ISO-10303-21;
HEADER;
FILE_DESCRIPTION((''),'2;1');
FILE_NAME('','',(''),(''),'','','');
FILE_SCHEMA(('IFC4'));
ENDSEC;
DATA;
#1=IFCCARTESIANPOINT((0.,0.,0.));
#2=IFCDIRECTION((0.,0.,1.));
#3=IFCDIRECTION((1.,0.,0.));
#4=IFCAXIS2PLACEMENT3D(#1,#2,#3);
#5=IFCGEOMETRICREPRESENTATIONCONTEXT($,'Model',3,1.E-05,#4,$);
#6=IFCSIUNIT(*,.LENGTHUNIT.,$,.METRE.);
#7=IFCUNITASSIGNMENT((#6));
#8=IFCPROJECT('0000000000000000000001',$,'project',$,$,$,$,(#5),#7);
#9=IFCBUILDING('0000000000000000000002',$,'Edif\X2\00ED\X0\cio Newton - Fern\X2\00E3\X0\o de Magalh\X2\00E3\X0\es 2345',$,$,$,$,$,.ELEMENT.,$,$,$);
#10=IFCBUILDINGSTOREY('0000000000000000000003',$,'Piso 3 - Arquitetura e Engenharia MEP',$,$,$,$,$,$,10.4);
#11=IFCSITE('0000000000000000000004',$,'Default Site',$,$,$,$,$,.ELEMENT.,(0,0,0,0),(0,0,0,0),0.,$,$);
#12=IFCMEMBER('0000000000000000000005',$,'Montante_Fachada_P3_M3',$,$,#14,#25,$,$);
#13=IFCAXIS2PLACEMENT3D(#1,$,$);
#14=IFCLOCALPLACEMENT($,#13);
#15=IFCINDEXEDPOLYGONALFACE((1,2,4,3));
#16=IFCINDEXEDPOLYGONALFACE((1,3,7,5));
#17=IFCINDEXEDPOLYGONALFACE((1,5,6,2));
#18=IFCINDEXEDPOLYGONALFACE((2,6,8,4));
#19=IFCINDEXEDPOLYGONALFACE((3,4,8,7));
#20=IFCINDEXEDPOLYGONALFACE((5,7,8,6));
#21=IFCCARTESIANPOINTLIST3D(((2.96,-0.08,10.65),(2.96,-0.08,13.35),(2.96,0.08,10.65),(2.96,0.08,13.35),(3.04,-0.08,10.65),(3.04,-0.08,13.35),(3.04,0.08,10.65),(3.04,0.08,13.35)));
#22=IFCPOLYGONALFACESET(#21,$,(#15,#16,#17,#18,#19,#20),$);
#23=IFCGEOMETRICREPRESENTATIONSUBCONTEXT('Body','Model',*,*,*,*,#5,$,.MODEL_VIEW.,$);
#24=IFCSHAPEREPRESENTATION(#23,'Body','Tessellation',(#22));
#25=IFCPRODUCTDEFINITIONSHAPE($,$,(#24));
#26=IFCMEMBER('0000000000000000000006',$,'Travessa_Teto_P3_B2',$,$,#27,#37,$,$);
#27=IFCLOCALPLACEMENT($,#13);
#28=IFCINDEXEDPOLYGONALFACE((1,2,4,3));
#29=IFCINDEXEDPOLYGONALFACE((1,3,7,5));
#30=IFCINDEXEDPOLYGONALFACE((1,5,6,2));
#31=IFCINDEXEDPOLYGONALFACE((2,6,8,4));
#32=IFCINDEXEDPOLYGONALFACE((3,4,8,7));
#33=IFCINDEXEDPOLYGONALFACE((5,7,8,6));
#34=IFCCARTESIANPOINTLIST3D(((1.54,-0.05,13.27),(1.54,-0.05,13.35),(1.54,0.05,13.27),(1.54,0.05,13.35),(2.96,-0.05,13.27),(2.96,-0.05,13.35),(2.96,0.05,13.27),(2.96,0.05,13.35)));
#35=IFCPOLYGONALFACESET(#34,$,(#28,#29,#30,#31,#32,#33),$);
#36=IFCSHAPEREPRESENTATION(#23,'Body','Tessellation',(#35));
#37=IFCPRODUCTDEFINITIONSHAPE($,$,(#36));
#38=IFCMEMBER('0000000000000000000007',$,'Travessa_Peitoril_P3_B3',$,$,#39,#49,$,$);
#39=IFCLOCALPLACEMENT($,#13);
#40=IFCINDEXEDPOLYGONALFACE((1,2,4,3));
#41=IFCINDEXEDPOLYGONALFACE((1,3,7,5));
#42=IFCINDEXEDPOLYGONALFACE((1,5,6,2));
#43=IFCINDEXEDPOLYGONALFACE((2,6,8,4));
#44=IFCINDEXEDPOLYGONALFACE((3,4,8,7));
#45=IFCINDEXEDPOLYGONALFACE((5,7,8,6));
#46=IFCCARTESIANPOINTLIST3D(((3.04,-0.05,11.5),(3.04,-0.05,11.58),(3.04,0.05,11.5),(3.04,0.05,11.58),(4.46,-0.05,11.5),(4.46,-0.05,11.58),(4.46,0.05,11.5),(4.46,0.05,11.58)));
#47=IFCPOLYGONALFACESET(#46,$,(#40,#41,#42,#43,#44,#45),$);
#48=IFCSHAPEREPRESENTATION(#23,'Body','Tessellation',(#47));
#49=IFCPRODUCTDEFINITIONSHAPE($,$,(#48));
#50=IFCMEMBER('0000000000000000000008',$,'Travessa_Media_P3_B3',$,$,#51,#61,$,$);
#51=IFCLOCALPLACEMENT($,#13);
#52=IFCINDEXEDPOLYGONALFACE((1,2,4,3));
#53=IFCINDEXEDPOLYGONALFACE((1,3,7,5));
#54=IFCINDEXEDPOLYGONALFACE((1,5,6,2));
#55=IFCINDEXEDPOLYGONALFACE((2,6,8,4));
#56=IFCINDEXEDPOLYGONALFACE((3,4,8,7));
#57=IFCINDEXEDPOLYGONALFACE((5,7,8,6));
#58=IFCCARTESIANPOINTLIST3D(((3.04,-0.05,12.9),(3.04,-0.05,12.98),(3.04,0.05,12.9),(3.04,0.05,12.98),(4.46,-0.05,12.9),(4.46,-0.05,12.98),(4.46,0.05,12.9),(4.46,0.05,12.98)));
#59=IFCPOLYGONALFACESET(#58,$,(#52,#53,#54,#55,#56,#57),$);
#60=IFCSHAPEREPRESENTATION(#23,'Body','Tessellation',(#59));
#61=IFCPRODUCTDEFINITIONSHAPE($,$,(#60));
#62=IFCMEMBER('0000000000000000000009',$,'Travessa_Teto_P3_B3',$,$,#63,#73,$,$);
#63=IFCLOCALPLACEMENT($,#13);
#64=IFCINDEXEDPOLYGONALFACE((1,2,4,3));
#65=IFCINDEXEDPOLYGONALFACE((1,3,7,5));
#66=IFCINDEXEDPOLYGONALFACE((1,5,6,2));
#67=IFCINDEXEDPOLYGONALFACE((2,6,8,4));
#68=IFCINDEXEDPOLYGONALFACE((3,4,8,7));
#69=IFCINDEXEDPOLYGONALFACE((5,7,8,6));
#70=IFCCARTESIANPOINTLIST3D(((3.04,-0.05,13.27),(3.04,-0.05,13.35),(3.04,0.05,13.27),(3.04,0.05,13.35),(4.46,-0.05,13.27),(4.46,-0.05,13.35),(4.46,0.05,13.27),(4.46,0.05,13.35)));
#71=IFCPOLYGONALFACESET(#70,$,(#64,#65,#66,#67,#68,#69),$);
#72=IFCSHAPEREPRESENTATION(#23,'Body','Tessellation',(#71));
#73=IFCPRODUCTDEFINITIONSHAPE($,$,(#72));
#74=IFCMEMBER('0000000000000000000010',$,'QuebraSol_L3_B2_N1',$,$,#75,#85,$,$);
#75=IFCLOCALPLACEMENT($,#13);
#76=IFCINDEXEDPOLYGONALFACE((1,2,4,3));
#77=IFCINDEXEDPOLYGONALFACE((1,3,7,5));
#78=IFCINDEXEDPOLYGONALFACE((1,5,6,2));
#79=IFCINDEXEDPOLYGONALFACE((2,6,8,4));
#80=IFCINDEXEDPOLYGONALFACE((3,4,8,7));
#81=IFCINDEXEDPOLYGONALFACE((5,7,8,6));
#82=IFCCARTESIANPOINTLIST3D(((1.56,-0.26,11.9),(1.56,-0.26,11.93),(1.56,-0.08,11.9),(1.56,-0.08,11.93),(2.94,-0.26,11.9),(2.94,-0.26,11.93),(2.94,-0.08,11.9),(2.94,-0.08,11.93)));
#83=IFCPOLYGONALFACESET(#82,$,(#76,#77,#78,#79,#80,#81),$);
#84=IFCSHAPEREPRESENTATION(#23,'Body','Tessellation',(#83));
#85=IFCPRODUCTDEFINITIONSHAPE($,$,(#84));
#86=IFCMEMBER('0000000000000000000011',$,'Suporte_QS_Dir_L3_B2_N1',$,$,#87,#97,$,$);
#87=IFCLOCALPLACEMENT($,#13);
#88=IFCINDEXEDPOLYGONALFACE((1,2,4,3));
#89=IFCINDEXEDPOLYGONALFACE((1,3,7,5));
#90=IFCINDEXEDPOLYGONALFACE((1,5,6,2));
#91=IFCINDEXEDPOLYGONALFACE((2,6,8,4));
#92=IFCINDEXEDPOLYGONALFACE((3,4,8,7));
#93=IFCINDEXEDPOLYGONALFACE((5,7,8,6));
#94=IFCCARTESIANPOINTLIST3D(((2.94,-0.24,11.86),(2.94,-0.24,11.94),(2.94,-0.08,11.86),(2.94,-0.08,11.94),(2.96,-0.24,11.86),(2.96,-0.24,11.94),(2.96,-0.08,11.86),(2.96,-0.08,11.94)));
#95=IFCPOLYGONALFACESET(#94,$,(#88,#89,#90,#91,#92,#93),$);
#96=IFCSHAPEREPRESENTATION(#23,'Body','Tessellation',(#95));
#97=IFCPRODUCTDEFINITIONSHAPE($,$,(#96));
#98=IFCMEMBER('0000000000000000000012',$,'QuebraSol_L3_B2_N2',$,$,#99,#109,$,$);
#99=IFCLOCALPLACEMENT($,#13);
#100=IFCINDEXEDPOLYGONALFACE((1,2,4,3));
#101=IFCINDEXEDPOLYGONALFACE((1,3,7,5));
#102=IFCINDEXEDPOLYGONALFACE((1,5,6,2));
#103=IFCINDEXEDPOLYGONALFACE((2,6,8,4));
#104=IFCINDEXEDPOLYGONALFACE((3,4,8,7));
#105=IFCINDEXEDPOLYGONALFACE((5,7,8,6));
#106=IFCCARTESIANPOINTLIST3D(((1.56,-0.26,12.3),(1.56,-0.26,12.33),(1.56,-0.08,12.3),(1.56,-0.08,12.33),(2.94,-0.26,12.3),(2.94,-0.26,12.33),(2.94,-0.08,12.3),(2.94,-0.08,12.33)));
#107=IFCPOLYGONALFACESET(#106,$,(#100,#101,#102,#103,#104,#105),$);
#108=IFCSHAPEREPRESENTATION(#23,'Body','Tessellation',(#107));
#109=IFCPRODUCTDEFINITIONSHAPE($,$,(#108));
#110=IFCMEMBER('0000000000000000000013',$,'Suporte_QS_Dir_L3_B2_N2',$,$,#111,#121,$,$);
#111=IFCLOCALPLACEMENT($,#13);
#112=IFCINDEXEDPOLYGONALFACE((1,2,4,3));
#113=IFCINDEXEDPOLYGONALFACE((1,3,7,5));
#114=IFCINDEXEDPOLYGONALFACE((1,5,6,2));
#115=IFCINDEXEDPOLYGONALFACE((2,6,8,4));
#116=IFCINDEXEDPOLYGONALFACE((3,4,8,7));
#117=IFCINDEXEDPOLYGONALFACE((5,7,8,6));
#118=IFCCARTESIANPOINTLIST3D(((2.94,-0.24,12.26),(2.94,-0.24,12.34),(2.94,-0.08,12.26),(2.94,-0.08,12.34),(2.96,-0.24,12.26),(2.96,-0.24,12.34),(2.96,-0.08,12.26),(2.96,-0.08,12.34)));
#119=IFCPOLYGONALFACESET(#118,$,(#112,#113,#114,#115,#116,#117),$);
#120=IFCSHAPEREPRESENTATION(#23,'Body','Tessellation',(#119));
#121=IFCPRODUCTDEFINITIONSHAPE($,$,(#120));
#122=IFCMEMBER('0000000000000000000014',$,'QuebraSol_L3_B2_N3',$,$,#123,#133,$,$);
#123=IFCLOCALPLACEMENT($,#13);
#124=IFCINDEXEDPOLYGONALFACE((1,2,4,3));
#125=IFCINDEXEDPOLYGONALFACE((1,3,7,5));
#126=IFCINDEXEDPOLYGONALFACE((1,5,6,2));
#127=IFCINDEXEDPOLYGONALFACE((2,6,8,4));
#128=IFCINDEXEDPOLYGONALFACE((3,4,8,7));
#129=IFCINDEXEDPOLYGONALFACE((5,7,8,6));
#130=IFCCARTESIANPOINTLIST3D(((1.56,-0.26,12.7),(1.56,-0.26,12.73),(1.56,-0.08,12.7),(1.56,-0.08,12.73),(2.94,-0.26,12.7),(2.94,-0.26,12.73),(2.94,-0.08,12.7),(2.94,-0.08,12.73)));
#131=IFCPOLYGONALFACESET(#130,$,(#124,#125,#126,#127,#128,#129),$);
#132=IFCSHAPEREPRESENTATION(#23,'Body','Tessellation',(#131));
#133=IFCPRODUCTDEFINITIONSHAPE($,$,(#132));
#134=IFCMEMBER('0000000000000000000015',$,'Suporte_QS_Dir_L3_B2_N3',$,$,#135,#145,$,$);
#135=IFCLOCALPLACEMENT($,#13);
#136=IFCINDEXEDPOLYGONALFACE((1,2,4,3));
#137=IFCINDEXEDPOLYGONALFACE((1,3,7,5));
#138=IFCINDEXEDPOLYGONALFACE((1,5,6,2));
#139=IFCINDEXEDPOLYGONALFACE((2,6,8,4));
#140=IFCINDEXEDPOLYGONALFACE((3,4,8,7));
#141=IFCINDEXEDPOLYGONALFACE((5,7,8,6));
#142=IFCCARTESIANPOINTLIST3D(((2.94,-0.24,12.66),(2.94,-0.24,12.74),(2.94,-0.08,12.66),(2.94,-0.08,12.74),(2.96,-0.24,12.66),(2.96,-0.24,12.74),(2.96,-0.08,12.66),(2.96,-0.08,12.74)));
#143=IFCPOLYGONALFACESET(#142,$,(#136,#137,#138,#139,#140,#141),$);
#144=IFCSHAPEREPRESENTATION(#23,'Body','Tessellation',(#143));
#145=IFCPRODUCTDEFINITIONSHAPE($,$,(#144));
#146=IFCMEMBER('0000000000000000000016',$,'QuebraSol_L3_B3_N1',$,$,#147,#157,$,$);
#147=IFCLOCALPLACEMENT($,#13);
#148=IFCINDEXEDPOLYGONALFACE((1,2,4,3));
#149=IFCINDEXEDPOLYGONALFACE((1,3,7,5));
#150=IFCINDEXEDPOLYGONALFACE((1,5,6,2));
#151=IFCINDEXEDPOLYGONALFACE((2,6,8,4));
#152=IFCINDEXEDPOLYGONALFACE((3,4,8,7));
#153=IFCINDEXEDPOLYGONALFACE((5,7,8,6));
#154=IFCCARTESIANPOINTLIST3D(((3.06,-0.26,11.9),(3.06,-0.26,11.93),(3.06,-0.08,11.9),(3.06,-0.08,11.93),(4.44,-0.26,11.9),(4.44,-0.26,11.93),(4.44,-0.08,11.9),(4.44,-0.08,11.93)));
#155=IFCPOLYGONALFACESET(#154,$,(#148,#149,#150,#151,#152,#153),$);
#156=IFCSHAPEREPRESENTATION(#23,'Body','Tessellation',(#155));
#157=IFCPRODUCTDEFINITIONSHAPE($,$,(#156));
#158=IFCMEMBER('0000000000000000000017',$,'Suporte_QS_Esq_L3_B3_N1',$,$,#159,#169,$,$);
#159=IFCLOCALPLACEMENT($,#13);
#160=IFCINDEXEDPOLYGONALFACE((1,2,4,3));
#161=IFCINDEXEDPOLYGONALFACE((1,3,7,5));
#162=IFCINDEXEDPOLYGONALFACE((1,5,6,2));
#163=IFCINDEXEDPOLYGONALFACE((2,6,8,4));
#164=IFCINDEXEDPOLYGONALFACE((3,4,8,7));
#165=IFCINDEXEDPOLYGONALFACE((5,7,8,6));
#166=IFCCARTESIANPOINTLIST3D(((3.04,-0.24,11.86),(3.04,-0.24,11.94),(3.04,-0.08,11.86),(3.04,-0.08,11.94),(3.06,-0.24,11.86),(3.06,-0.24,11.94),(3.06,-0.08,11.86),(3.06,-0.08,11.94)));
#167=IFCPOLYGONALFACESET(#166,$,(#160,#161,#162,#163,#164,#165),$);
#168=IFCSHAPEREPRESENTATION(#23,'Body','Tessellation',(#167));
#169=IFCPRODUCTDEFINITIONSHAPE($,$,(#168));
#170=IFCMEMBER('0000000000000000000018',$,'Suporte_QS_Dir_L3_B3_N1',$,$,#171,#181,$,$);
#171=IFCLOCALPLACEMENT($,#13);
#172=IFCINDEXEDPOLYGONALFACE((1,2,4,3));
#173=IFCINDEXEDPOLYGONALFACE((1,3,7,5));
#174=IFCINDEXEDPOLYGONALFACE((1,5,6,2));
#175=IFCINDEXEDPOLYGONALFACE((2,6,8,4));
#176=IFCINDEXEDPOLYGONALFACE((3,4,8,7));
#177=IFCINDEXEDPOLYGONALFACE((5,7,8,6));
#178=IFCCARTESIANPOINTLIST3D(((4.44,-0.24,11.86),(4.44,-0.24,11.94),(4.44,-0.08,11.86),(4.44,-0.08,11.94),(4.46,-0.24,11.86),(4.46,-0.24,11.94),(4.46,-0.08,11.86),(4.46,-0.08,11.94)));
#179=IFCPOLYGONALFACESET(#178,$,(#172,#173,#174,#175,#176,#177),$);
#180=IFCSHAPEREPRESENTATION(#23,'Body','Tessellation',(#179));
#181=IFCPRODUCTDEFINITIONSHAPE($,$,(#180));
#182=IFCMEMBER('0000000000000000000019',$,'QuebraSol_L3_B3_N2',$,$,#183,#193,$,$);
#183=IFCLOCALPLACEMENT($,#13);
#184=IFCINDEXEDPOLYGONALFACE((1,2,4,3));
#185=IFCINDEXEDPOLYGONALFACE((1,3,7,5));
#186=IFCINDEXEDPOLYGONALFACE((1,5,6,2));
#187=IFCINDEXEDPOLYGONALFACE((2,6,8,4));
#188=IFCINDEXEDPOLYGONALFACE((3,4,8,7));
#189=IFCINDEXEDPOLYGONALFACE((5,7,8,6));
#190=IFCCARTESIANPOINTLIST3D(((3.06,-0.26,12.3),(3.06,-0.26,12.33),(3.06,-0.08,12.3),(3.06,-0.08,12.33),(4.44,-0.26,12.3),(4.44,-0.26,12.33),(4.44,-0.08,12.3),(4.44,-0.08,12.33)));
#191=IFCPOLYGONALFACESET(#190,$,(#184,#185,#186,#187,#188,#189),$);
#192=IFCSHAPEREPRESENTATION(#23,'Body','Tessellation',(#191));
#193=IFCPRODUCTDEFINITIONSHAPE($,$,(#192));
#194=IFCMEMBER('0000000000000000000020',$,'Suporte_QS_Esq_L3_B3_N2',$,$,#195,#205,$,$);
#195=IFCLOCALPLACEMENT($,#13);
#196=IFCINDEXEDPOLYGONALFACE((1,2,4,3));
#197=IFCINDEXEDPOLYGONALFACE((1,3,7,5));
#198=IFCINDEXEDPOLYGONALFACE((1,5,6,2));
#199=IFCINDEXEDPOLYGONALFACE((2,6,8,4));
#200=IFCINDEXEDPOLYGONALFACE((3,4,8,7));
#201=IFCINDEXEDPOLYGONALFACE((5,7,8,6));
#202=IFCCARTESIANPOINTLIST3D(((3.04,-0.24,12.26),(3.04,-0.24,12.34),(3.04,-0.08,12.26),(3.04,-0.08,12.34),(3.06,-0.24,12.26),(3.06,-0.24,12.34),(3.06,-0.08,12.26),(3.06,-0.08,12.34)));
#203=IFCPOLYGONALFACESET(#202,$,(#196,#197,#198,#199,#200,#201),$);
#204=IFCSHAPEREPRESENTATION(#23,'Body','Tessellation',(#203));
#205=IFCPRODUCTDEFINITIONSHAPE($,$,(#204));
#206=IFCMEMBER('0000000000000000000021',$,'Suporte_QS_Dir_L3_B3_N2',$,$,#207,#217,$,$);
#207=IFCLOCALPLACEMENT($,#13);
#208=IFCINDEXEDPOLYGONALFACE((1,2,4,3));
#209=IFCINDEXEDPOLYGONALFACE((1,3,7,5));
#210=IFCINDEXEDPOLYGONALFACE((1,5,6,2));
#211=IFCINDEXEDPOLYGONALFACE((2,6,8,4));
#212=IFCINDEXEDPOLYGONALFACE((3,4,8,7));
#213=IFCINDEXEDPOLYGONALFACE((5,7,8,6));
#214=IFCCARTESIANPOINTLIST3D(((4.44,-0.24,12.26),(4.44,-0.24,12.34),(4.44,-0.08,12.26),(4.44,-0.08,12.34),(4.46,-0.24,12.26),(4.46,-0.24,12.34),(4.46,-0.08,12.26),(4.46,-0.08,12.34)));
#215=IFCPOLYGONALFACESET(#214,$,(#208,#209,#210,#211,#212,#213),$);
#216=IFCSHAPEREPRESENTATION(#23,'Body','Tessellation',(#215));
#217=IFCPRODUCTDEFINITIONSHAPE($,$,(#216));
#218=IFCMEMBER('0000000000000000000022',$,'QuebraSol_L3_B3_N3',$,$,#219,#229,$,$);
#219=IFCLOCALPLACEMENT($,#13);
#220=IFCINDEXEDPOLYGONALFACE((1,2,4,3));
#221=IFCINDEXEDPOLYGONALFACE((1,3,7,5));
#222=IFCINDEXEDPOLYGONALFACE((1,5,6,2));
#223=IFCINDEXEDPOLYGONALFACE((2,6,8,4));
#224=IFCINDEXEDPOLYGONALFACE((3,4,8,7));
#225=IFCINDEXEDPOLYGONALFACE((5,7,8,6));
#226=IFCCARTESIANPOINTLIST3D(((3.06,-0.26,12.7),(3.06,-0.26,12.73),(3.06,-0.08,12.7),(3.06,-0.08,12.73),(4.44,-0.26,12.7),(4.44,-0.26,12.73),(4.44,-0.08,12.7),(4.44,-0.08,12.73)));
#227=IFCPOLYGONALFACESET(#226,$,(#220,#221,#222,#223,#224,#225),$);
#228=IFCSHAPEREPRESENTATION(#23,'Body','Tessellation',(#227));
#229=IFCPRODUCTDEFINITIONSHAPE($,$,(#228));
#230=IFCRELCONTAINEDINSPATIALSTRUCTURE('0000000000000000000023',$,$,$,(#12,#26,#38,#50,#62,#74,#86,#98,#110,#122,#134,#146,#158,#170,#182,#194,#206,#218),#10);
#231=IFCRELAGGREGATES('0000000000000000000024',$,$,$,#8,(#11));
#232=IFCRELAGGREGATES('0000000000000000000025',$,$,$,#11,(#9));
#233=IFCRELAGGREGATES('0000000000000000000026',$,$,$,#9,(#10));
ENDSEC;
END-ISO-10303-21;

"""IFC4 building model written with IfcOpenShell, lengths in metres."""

from ifc_helpers import new_model, si_unit, frame, frame_2d, origin_with_axes, place, context, subcontext, project, spatial, rectangle, extrude, element, save


model = new_model("IFC4")

# Units and contexts
model_context = context("Model", 3, precision=1e-05, world=origin_with_axes())
body_context = subcontext(model_context, "Body", "Model", "MODEL_VIEW")
ifc_project = project(units=[si_unit("LENGTHUNIT", "METRE")], contexts=[model_context])

# Site, building, storey
site = spatial("IfcSite", under=ifc_project, Name="Default Site", CompositionType="ELEMENT", RefLatitude=(0, 0, 0, 0), RefLongitude=(0, 0, 0, 0), RefElevation=0.0)
building = spatial("IfcBuilding", under=site, Name="Edifício Newton - Fernão de Magalhães 2345", CompositionType="ELEMENT")
storey = spatial("IfcBuildingStorey", under=building, Name="Piso 3 - Arquitetura e Engenharia MEP", Elevation=10.4)

# Members
member_1_placement = place(None, frame((2.96, -0.08, 10.65), z_axis=(0.0, 0.0, 1.0), x_axis=(1.0, 0.0, 0.0)))
element("IfcMember", 1, at=member_1_placement, inside=storey, Name="Montante_Fachada_P3_M3", context=body_context, shape_type="SweptSolid", body=[
    extrude(rectangle(XDim=0.08, YDim=0.16, at=frame_2d((0.04, 0.08))), origin_with_axes(), (0.0, 0.0, 1.0), 2.7),
])
for number, where, z_axis, x_axis, name in (
    (2, (1.54, -0.05, 13.27), (0.0, 0.0, 1.0), (1.0, 0.0, 0.0), "Travessa_Teto_P3_B2"),
    (3, (3.04, -0.05, 11.5), (0.0, 0.0, 1.0), (1.0, 0.0, 0.0), "Travessa_Peitoril_P3_B3"),
    (4, (3.04, -0.05, 12.9), (0.0, 0.0, 1.0), (1.0, 0.0, 0.0), "Travessa_Media_P3_B3"),
    (5, (3.04, -0.05, 13.27), (0.0, 0.0, 1.0), (1.0, 0.0, 0.0), "Travessa_Teto_P3_B3"),
):
    element("IfcMember", number, at=place(None, frame(where, z_axis=z_axis, x_axis=x_axis)), inside=storey, Name=name, context=body_context, shape_type="SweptSolid", body=[
        extrude(rectangle(XDim=1.42, YDim=0.1, at=frame_2d((0.71, 0.05))), origin_with_axes(), (0.0, 0.0, 1.0), 0.08),
    ])
member_2_placement = place(None, frame((1.56, -0.26, 11.9), z_axis=(0.0, 0.0, 1.0), x_axis=(1.0, 0.0, 0.0)))
element("IfcMember", 6, at=member_2_placement, inside=storey, Name="QuebraSol_L3_B2_N1", context=body_context, shape_type="SweptSolid", body=[
    extrude(rectangle(XDim=1.38, YDim=0.18, at=frame_2d((0.69, 0.09))), origin_with_axes(), (0.0, 0.0, 1.0), 0.03),
])
member_3_placement = place(None, frame((2.94, -0.24, 11.86), z_axis=(0.0, 0.0, 1.0), x_axis=(1.0, 0.0, 0.0)))
element("IfcMember", 7, at=member_3_placement, inside=storey, Name="Suporte_QS_Dir_L3_B2_N1", context=body_context, shape_type="SweptSolid", body=[
    extrude(rectangle(XDim=0.02, YDim=0.16, at=frame_2d((0.01, 0.08))), origin_with_axes(), (0.0, 0.0, 1.0), 0.08),
])
member_4_placement = place(None, frame((1.56, -0.26, 12.3), z_axis=(0.0, 0.0, 1.0), x_axis=(1.0, 0.0, 0.0)))
element("IfcMember", 8, at=member_4_placement, inside=storey, Name="QuebraSol_L3_B2_N2", context=body_context, shape_type="SweptSolid", body=[
    extrude(rectangle(XDim=1.38, YDim=0.18, at=frame_2d((0.69, 0.09))), origin_with_axes(), (0.0, 0.0, 1.0), 0.03),
])
member_5_placement = place(None, frame((2.94, -0.24, 12.26), z_axis=(0.0, 0.0, 1.0), x_axis=(1.0, 0.0, 0.0)))
element("IfcMember", 9, at=member_5_placement, inside=storey, Name="Suporte_QS_Dir_L3_B2_N2", context=body_context, shape_type="SweptSolid", body=[
    extrude(rectangle(XDim=0.02, YDim=0.16, at=frame_2d((0.01, 0.08))), origin_with_axes(), (0.0, 0.0, 1.0), 0.08),
])
member_6_placement = place(None, frame((1.56, -0.26, 12.7), z_axis=(0.0, 0.0, 1.0), x_axis=(1.0, 0.0, 0.0)))
element("IfcMember", 10, at=member_6_placement, inside=storey, Name="QuebraSol_L3_B2_N3", context=body_context, shape_type="SweptSolid", body=[
    extrude(rectangle(XDim=1.38, YDim=0.18, at=frame_2d((0.69, 0.09))), origin_with_axes(), (0.0, 0.0, 1.0), 0.03),
])
member_7_placement = place(None, frame((2.94, -0.24, 12.66), z_axis=(0.0, 0.0, 1.0), x_axis=(1.0, 0.0, 0.0)))
element("IfcMember", 11, at=member_7_placement, inside=storey, Name="Suporte_QS_Dir_L3_B2_N3", context=body_context, shape_type="SweptSolid", body=[
    extrude(rectangle(XDim=0.02, YDim=0.16, at=frame_2d((0.01, 0.08))), origin_with_axes(), (0.0, 0.0, 1.0), 0.08),
])
member_8_placement = place(None, frame((3.06, -0.26, 11.9), z_axis=(0.0, 0.0, 1.0), x_axis=(1.0, 0.0, 0.0)))
element("IfcMember", 12, at=member_8_placement, inside=storey, Name="QuebraSol_L3_B3_N1", context=body_context, shape_type="SweptSolid", body=[
    extrude(rectangle(XDim=1.38, YDim=0.18, at=frame_2d((0.69, 0.09))), origin_with_axes(), (0.0, 0.0, 1.0), 0.03),
])
for number, where, z_axis, x_axis, name in (
    (13, (3.04, -0.24, 11.86), (0.0, 0.0, 1.0), (1.0, 0.0, 0.0), "Suporte_QS_Esq_L3_B3_N1"),
    (14, (4.44, -0.24, 11.86), (0.0, 0.0, 1.0), (1.0, 0.0, 0.0), "Suporte_QS_Dir_L3_B3_N1"),
):
    element("IfcMember", number, at=place(None, frame(where, z_axis=z_axis, x_axis=x_axis)), inside=storey, Name=name, context=body_context, shape_type="SweptSolid", body=[
        extrude(rectangle(XDim=0.02, YDim=0.16, at=frame_2d((0.01, 0.08))), origin_with_axes(), (0.0, 0.0, 1.0), 0.08),
    ])
member_9_placement = place(None, frame((3.06, -0.26, 12.3), z_axis=(0.0, 0.0, 1.0), x_axis=(1.0, 0.0, 0.0)))
element("IfcMember", 15, at=member_9_placement, inside=storey, Name="QuebraSol_L3_B3_N2", context=body_context, shape_type="SweptSolid", body=[
    extrude(rectangle(XDim=1.38, YDim=0.18, at=frame_2d((0.69, 0.09))), origin_with_axes(), (0.0, 0.0, 1.0), 0.03),
])
for number, where, z_axis, x_axis, name in (
    (16, (3.04, -0.24, 12.26), (0.0, 0.0, 1.0), (1.0, 0.0, 0.0), "Suporte_QS_Esq_L3_B3_N2"),
    (17, (4.44, -0.24, 12.26), (0.0, 0.0, 1.0), (1.0, 0.0, 0.0), "Suporte_QS_Dir_L3_B3_N2"),
):
    element("IfcMember", number, at=place(None, frame(where, z_axis=z_axis, x_axis=x_axis)), inside=storey, Name=name, context=body_context, shape_type="SweptSolid", body=[
        extrude(rectangle(XDim=0.02, YDim=0.16, at=frame_2d((0.01, 0.08))), origin_with_axes(), (0.0, 0.0, 1.0), 0.08),
    ])
member_10_placement = place(None, frame((3.06, -0.26, 12.7), z_axis=(0.0, 0.0, 1.0), x_axis=(1.0, 0.0, 0.0)))
element("IfcMember", 18, at=member_10_placement, inside=storey, Name="QuebraSol_L3_B3_N3", context=body_context, shape_type="SweptSolid", body=[
    extrude(rectangle(XDim=1.38, YDim=0.18, at=frame_2d((0.69, 0.09))), origin_with_axes(), (0.0, 0.0, 1.0), 0.03),
])

save(model, "model.ifc")
